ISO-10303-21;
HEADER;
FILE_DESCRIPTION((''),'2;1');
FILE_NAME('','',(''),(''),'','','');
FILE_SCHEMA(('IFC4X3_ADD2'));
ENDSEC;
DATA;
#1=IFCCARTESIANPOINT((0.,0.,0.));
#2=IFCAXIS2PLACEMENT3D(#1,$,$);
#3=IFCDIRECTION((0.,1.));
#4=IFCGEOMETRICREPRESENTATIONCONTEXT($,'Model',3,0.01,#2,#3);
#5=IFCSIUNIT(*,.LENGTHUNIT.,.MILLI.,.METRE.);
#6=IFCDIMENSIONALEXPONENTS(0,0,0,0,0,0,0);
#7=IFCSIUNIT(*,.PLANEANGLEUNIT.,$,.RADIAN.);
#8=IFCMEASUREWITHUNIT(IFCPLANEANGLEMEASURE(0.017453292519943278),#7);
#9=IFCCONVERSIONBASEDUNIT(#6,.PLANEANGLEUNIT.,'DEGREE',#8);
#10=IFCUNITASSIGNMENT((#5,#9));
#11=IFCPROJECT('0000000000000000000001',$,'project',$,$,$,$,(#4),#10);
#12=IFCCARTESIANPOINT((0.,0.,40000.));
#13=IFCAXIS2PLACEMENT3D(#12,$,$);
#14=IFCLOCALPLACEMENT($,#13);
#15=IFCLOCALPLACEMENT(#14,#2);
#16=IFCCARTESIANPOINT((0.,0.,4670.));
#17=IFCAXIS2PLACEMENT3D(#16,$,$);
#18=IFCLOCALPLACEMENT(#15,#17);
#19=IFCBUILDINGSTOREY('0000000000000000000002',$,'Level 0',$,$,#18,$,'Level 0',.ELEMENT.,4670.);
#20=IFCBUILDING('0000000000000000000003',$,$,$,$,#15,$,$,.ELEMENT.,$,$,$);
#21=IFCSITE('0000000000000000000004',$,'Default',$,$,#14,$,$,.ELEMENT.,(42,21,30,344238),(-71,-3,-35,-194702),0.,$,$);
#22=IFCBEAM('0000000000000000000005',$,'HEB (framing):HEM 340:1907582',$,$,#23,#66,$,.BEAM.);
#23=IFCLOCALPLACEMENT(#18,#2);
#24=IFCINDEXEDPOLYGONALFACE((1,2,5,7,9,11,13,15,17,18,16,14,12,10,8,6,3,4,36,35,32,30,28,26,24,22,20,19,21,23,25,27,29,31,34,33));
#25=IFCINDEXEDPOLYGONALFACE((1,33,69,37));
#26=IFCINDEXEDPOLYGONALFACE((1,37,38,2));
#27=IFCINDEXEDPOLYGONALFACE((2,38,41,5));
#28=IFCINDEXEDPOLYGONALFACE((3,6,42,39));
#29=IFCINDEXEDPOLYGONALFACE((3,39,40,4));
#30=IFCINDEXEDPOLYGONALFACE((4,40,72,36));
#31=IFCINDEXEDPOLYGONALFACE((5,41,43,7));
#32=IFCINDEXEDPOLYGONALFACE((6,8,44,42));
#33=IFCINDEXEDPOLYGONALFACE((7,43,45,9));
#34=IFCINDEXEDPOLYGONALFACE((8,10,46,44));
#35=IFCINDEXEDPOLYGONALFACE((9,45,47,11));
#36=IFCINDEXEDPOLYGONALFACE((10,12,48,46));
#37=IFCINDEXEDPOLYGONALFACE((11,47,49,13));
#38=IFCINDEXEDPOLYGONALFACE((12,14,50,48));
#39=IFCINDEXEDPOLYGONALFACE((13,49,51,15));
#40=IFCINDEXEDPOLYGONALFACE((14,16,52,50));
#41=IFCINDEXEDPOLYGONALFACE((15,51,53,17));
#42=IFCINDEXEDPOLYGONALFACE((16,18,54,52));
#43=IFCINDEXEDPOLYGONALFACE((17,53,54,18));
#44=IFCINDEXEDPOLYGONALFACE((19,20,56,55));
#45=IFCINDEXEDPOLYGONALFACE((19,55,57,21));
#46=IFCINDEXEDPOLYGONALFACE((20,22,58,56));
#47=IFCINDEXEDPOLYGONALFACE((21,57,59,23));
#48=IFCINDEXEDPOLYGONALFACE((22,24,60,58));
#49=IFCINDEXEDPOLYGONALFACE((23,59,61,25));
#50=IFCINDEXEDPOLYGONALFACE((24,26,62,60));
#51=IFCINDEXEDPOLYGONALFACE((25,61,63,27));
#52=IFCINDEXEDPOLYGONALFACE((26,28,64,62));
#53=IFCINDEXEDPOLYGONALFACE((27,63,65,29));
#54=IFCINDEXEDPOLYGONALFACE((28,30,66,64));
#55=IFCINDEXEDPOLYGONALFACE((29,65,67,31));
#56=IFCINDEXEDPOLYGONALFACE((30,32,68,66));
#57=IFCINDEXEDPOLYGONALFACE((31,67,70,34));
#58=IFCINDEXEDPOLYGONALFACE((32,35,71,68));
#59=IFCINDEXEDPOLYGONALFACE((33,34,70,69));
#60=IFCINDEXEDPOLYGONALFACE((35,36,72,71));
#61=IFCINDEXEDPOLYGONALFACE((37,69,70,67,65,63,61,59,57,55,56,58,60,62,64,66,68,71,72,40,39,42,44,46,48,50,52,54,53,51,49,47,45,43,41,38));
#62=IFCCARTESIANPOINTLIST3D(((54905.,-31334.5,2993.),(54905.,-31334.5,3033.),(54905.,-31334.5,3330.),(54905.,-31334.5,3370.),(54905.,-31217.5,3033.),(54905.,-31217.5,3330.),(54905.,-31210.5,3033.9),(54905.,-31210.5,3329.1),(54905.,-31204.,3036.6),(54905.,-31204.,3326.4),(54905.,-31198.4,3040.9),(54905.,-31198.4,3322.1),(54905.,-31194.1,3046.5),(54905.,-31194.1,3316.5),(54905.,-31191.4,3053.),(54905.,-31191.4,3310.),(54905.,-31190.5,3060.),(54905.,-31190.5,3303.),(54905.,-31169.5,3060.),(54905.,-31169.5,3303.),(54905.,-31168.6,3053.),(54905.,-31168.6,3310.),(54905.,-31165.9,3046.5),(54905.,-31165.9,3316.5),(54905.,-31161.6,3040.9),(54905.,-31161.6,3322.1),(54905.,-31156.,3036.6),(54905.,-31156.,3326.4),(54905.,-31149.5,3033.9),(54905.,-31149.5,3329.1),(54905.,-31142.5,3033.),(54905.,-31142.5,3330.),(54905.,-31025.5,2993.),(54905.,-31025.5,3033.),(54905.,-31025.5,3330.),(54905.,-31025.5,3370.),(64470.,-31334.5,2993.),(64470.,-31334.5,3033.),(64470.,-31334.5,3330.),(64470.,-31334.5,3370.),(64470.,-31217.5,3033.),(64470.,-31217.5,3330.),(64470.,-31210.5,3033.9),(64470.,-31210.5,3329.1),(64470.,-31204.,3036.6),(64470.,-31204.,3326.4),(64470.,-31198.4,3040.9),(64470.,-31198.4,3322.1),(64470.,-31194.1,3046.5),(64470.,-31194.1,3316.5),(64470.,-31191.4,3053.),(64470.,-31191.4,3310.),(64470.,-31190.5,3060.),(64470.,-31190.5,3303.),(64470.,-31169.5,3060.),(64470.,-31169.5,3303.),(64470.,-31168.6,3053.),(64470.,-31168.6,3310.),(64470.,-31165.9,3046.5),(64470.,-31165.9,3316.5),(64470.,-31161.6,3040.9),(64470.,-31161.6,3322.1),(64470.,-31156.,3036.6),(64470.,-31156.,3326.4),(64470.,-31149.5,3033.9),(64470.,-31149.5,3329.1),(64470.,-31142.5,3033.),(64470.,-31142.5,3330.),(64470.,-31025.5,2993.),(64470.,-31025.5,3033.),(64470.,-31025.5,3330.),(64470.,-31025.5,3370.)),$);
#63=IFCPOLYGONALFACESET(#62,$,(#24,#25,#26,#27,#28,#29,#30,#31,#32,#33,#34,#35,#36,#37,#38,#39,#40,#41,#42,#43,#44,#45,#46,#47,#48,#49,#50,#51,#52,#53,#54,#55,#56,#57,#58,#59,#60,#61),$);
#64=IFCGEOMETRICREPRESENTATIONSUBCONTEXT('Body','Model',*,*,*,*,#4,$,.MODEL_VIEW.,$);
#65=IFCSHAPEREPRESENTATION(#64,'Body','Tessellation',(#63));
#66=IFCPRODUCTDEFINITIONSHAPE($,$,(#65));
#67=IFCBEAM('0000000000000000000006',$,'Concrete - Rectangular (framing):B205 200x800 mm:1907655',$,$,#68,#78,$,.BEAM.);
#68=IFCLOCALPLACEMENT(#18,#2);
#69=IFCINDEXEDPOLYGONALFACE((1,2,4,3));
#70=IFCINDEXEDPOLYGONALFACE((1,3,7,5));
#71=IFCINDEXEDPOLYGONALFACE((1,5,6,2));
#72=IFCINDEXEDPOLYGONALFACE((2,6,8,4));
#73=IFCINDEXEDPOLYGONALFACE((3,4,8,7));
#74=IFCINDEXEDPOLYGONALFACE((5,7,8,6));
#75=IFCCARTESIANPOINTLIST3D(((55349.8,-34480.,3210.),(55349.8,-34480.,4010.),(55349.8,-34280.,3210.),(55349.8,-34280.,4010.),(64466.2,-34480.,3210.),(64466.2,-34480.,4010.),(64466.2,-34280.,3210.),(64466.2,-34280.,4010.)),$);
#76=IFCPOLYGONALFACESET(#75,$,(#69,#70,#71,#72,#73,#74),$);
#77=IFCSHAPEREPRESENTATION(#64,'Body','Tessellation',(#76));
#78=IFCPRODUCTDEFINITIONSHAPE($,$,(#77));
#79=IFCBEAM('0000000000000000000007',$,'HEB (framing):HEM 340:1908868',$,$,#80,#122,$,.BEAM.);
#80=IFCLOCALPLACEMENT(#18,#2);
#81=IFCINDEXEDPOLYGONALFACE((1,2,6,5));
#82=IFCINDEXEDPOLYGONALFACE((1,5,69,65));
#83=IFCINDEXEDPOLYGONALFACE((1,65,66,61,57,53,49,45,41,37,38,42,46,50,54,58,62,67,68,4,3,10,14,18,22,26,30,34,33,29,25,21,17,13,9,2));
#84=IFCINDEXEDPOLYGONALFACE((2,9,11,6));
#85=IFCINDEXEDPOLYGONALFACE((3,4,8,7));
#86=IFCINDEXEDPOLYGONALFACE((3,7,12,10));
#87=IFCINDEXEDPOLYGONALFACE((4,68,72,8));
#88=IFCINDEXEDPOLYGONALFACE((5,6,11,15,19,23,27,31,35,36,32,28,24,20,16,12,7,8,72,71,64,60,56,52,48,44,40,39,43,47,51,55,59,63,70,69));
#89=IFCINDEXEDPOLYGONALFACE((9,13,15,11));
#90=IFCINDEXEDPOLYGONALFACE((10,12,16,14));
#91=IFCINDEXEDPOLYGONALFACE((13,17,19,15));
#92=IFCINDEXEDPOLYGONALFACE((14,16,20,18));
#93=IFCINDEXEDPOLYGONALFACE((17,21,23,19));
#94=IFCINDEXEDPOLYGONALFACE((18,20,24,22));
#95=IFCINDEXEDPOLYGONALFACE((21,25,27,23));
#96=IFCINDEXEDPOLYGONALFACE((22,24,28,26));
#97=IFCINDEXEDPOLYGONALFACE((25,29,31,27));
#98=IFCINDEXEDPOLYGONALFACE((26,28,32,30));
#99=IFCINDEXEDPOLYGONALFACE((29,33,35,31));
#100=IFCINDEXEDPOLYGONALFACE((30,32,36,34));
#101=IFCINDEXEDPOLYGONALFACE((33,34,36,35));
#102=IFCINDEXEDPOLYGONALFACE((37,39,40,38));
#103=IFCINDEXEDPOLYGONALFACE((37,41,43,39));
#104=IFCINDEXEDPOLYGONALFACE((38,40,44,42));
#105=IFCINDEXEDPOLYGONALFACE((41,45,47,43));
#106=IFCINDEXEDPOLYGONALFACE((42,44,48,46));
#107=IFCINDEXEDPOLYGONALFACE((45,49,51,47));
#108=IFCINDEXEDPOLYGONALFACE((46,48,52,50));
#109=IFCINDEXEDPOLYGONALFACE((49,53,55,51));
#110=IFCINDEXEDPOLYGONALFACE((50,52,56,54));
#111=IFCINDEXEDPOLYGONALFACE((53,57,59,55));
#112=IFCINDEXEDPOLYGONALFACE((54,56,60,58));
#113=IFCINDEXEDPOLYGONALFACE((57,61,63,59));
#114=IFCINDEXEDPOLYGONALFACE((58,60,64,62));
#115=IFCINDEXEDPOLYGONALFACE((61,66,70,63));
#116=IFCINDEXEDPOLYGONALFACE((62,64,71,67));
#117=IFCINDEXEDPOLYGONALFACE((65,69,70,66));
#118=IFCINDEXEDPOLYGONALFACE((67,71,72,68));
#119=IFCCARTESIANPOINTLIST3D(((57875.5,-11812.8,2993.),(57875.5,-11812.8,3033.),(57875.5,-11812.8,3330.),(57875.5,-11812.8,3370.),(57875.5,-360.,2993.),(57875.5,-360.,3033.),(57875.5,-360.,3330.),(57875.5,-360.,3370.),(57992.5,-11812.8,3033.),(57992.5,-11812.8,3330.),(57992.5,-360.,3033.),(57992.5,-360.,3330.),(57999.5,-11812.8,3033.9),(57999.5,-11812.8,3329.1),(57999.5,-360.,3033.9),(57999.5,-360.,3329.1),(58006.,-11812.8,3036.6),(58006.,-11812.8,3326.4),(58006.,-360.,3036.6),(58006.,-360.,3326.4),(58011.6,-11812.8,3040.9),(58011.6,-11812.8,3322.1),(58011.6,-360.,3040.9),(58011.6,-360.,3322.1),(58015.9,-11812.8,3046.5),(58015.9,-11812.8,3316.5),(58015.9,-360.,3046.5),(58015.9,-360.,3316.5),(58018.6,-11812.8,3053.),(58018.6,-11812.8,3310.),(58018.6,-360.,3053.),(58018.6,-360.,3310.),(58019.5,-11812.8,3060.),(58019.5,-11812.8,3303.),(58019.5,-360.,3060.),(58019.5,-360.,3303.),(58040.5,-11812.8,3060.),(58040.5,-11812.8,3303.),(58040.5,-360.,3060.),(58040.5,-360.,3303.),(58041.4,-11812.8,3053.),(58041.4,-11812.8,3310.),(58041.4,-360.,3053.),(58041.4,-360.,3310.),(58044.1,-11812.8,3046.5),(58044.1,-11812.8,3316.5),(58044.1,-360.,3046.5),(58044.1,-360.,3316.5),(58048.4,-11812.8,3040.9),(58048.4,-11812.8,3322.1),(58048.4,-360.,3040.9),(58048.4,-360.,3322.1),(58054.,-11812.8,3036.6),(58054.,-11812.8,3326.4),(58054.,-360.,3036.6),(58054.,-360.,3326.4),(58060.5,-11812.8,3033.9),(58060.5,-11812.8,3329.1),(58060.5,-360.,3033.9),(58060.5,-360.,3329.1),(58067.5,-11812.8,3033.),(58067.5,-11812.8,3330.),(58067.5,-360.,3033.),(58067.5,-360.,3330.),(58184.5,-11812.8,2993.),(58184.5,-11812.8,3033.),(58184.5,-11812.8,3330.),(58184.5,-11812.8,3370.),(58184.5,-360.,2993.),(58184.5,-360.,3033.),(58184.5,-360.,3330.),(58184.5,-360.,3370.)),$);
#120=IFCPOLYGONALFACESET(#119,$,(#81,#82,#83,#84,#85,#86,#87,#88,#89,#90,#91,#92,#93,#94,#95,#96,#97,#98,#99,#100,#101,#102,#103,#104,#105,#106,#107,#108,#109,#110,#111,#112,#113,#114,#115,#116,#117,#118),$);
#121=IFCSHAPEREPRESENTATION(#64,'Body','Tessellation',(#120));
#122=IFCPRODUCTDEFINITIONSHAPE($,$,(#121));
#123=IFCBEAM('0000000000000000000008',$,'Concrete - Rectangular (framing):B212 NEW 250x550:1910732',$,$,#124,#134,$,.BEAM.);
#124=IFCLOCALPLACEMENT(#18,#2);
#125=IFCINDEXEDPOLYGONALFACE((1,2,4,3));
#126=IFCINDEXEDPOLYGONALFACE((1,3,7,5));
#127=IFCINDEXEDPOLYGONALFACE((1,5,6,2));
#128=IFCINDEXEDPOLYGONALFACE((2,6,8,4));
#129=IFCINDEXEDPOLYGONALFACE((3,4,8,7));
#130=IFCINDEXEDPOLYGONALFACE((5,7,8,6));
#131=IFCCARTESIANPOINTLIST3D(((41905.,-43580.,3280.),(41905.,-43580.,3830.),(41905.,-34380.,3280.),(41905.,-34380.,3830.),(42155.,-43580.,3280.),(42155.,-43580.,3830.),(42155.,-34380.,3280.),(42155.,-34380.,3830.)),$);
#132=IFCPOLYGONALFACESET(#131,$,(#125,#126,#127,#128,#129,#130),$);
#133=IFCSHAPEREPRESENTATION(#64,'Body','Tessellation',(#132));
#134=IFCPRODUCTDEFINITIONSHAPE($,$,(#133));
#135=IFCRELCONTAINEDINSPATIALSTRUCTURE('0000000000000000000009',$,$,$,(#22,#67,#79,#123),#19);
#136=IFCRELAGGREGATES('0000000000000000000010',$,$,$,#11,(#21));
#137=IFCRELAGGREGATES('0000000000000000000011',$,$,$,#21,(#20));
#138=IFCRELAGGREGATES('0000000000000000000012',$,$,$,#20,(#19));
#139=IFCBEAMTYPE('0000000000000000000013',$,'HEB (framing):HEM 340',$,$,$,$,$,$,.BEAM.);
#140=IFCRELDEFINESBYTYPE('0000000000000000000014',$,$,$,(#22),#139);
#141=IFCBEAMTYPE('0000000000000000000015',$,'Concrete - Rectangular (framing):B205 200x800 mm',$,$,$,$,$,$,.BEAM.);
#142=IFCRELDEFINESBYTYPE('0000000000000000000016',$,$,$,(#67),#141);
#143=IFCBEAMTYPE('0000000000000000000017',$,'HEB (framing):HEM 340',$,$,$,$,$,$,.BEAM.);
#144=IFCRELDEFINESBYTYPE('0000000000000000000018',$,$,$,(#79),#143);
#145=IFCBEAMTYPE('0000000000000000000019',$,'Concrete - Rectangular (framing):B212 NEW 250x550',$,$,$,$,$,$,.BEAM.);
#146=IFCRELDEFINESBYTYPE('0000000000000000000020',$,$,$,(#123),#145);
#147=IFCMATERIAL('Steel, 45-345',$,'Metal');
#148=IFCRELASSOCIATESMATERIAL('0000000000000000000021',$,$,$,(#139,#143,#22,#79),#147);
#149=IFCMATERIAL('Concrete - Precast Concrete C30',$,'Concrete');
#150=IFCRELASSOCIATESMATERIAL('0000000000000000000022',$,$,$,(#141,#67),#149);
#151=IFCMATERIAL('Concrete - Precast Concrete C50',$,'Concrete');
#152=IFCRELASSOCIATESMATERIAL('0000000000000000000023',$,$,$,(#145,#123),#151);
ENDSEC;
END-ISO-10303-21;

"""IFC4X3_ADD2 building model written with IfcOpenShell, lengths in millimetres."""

from ifc_helpers import new_model, entity, si_unit, converted_unit, direction, frame, frame_2d, origin, origin_2d_with_axis, place, context, subcontext, project, spatial, polyline, circle_curve, parameter, trimmed, segment, composite_curve, rectangle, outline, extrude, source, transform, mapped, material, material_profile, profile_set, profile_usage, type_object, type_shapes, element, save


model = new_model("IFC4X3_ADD2")

# Units and contexts
model_context = context("Model", 3, precision=0.01, world=origin(), true_north=direction((0.0, 1.0)))
body_context = subcontext(model_context, "Body", "Model", "MODEL_VIEW")
ifc_project = project(units=[si_unit("LENGTHUNIT", "METRE", prefix="MILLI"), converted_unit("PLANEANGLEUNIT", "DEGREE", entity("IfcPlaneAngleMeasure", 0.017453292519943278), si_unit("PLANEANGLEUNIT", "RADIAN"), dimensions=[0, 0, 0, 0, 0, 0, 0])], contexts=[model_context])

# Site, building, storey
site_placement = place(None, frame((0.0, 0.0, 40000.0)))
site = spatial("IfcSite", under=ifc_project, at=site_placement, Name="Default", CompositionType="ELEMENT", RefLatitude=(42, 21, 30, 344238), RefLongitude=(-71, -3, -35, -194702), RefElevation=0.0)
building_placement = place(site_placement, origin())
building = spatial("IfcBuilding", under=site, at=building_placement, CompositionType="ELEMENT")
storey_placement = place(building_placement, frame((0.0, 0.0, 4670.0)))
storey = spatial("IfcBuildingStorey", under=building, at=storey_placement, Name="Level 0", LongName="Level 0", CompositionType="ELEMENT", Elevation=4670.0)

# Shared definitions
ifc_material_1 = material(Name="Steel, 45-345", Category="Metal")

# Beams
ifc_material_profile_1 = material_profile(ifc_material_1, outline(composite_curve([segment(polyline([(-154.5, -148.5), (-154.5, -188.5)]), True, "CONTINUOUS"), segment(polyline([(-154.5, -188.5), (154.5, -188.5)]), True, "CONTINUOUS"), segment(polyline([(154.5, -188.5), (154.5, -148.5)]), True, "CONTINUOUS"), segment(polyline([(154.5, -148.5), (37.5, -148.5)]), True, "CONTINUOUS"), segment(trimmed(circle_curve(frame_2d((37.5, -121.5), x_axis=(1.0, 0.0)), 27.0), [parameter(180.0)], [parameter(270.0)], True, "PARAMETER"), False, "CONTINUOUS"), segment(polyline([(10.5, -121.5), (10.5, 121.5)]), True, "CONTINUOUS"), segment(trimmed(circle_curve(frame_2d((37.5, 121.5), x_axis=(1.0, 0.0)), 27.0), [parameter(90.0)], [parameter(180.0)], True, "PARAMETER"), False, "CONTINUOUS"), segment(polyline([(37.5, 148.5), (154.5, 148.5)]), True, "CONTINUOUS"), segment(polyline([(154.5, 148.5), (154.5, 188.5)]), True, "CONTINUOUS"), segment(polyline([(154.5, 188.5), (-154.5, 188.5)]), True, "CONTINUOUS"), segment(polyline([(-154.5, 188.5), (-154.5, 148.5)]), True, "CONTINUOUS"), segment(polyline([(-154.5, 148.5), (-37.5, 148.5)]), True, "CONTINUOUS"), segment(trimmed(circle_curve(frame_2d((-37.5, 121.5), x_axis=(1.0, 0.0)), 27.0), [parameter(360.0)], [parameter(90.0)], True, "PARAMETER"), False, "CONTINUOUS"), segment(polyline([(-10.5, 121.5), (-10.5, -121.5)]), True, "CONTINUOUS"), segment(trimmed(circle_curve(frame_2d((-37.5, -121.5), x_axis=(1.0, 0.0)), 27.0), [parameter(270.0)], [parameter(0.0)], True, "PARAMETER"), False, "CONTINUOUS"), segment(polyline([(-37.5, -148.5), (-154.5, -148.5)]), True, "CONTINUOUS")], self_intersect=False)), Name="HEM 340")
ifc_profile_set_1 = profile_set([ifc_material_profile_1], Name="HEM 340")
ifc_profile_usage_1 = profile_usage(ifc_profile_set_1, cardinal=8)
beam_type_1 = type_object("IfcBeamType", Name="HEB (framing):HEM 340", PredefinedType="BEAM", material=ifc_profile_set_1)
shared_shape_1 = source(origin(), body_context, "Body", "SweptSolid", [
    extrude(outline(composite_curve([segment(polyline([(-154.5, -148.5), (-154.5, -188.5)]), True, "CONTINUOUS"), segment(polyline([(-154.5, -188.5), (154.5, -188.5)]), True, "CONTINUOUS"), segment(polyline([(154.5, -188.5), (154.5, -148.5)]), True, "CONTINUOUS"), segment(polyline([(154.5, -148.5), (37.5, -148.5)]), True, "CONTINUOUS"), segment(trimmed(circle_curve(frame_2d((37.5, -121.5), x_axis=(1.0, 0.0)), 27.0), [parameter(180.0)], [parameter(270.0)], True, "PARAMETER"), False, "CONTINUOUS"), segment(polyline([(10.5, -121.5), (10.5, 121.5)]), True, "CONTINUOUS"), segment(trimmed(circle_curve(frame_2d((37.5, 121.5), x_axis=(1.0, 0.0)), 27.0), [parameter(90.0)], [parameter(180.0)], True, "PARAMETER"), False, "CONTINUOUS"), segment(polyline([(37.5, 148.5), (154.5, 148.5)]), True, "CONTINUOUS"), segment(polyline([(154.5, 148.5), (154.5, 188.5)]), True, "CONTINUOUS"), segment(polyline([(154.5, 188.5), (-154.5, 188.5)]), True, "CONTINUOUS"), segment(polyline([(-154.5, 188.5), (-154.5, 148.5)]), True, "CONTINUOUS"), segment(polyline([(-154.5, 148.5), (-37.5, 148.5)]), True, "CONTINUOUS"), segment(trimmed(circle_curve(frame_2d((-37.5, 121.5), x_axis=(1.0, 0.0)), 27.0), [parameter(360.0)], [parameter(90.0)], True, "PARAMETER"), False, "CONTINUOUS"), segment(polyline([(-10.5, 121.5), (-10.5, -121.5)]), True, "CONTINUOUS"), segment(trimmed(circle_curve(frame_2d((-37.5, -121.5), x_axis=(1.0, 0.0)), 27.0), [parameter(270.0)], [parameter(0.0)], True, "PARAMETER"), False, "CONTINUOUS"), segment(polyline([(-37.5, -148.5), (-154.5, -148.5)]), True, "CONTINUOUS")], self_intersect=False)), frame((-4680.0, 0.0, 0.0), z_axis=(-1.0, 0.0, 0.0), x_axis=(0.0, -1.0, 0.0)), (0.0, 0.0, -1.0), 9565.0),
])
type_shapes(beam_type_1, [shared_shape_1])
beam_1_placement = place(storey_placement, frame((59585.0, -31180.0, 3181.5)))
element("IfcBeam", 1, at=beam_1_placement, inside=storey, type_object=beam_type_1, material=ifc_profile_usage_1, Name="HEB (framing):HEM 340:1907582", PredefinedType="BEAM", context=body_context, shape_type="MappedRepresentation", body=[
    mapped(shared_shape_1, transform((0.0, 0.0, 0.0), scale=1.0)),
])
ifc_material_2 = material(Name="Concrete - Precast Concrete C30", Category="Concrete")
ifc_material_profile_2 = material_profile(ifc_material_2, rectangle(XDim=9116.4, YDim=200.0, at=origin_2d_with_axis()), Name="B205 200x800 mm")
ifc_profile_set_2 = profile_set([ifc_material_profile_2], Name="B205 200x800 mm")
ifc_profile_usage_2 = profile_usage(ifc_profile_set_2, cardinal=8)
beam_type_2 = type_object("IfcBeamType", Name="Concrete - Rectangular (framing):B205 200x800 mm", PredefinedType="BEAM", material=ifc_profile_set_2)
shared_shape_2 = source(origin(), body_context, "Body", "SweptSolid", [
    extrude(rectangle(XDim=9116.4, YDim=200.0, at=origin_2d_with_axis()), frame((453.0, 0.0, -400.0), z_axis=(0.0, 0.0, 1.0), x_axis=(-1.0, 0.0, 0.0)), (0.0, 0.0, 1.0), 800.0),
])
type_shapes(beam_type_2, [shared_shape_2])
beam_2_placement = place(storey_placement, frame((59455.0, -34380.0, 3610.0)))
element("IfcBeam", 2, at=beam_2_placement, inside=storey, type_object=beam_type_2, material=ifc_profile_usage_2, Name="Concrete - Rectangular (framing):B205 200x800 mm:1907655", PredefinedType="BEAM", context=body_context, shape_type="MappedRepresentation", body=[
    mapped(shared_shape_2, transform((0.0, 0.0, 0.0), scale=1.0)),
])
beam_type_3 = type_object("IfcBeamType", Name="HEB (framing):HEM 340", PredefinedType="BEAM", material=ifc_profile_set_1)
shared_shape_3 = source(origin(), body_context, "Body", "SweptSolid", [
    extrude(outline(composite_curve([segment(polyline([(-154.5, -148.5), (-154.5, -188.5)]), True, "CONTINUOUS"), segment(polyline([(-154.5, -188.5), (154.5, -188.5)]), True, "CONTINUOUS"), segment(polyline([(154.5, -188.5), (154.5, -148.5)]), True, "CONTINUOUS"), segment(polyline([(154.5, -148.5), (37.5, -148.5)]), True, "CONTINUOUS"), segment(trimmed(circle_curve(frame_2d((37.5, -121.5), x_axis=(1.0, 0.0)), 27.0), [parameter(180.0)], [parameter(270.0)], True, "PARAMETER"), False, "CONTINUOUS"), segment(polyline([(10.5, -121.5), (10.5, 121.5)]), True, "CONTINUOUS"), segment(trimmed(circle_curve(frame_2d((37.5, 121.5), x_axis=(1.0, 0.0)), 27.0), [parameter(90.0)], [parameter(180.0)], True, "PARAMETER"), False, "CONTINUOUS"), segment(polyline([(37.5, 148.5), (154.5, 148.5)]), True, "CONTINUOUS"), segment(polyline([(154.5, 148.5), (154.5, 188.5)]), True, "CONTINUOUS"), segment(polyline([(154.5, 188.5), (-154.5, 188.5)]), True, "CONTINUOUS"), segment(polyline([(-154.5, 188.5), (-154.5, 148.5)]), True, "CONTINUOUS"), segment(polyline([(-154.5, 148.5), (-37.5, 148.5)]), True, "CONTINUOUS"), segment(trimmed(circle_curve(frame_2d((-37.5, 121.5), x_axis=(1.0, 0.0)), 27.0), [parameter(360.0)], [parameter(90.0)], True, "PARAMETER"), False, "CONTINUOUS"), segment(polyline([(-10.5, 121.5), (-10.5, -121.5)]), True, "CONTINUOUS"), segment(trimmed(circle_curve(frame_2d((-37.5, -121.5), x_axis=(1.0, 0.0)), 27.0), [parameter(270.0)], [parameter(0.0)], True, "PARAMETER"), False, "CONTINUOUS"), segment(polyline([(-37.5, -148.5), (-154.5, -148.5)]), True, "CONTINUOUS")], self_intersect=False)), frame((-5860.0, 0.0, 0.0), z_axis=(-1.0, 0.0, 0.0), x_axis=(0.0, -1.0, 0.0)), (0.0, 0.0, -1.0), 11452.8),
])
type_shapes(beam_type_3, [shared_shape_3])
beam_3_placement = place(storey_placement, frame((58030.0, -6220.0, 3181.5), z_axis=(0.0, 0.0, 1.0), x_axis=(0.0, -1.0, 0.0)))
element("IfcBeam", 3, at=beam_3_placement, inside=storey, type_object=beam_type_3, material=ifc_profile_usage_1, Name="HEB (framing):HEM 340:1908868", PredefinedType="BEAM", context=body_context, shape_type="MappedRepresentation", body=[
    mapped(shared_shape_3, transform((0.0, 0.0, 0.0), scale=1.0)),
])
ifc_material_3 = material(Name="Concrete - Precast Concrete C50", Category="Concrete")
ifc_material_profile_3 = material_profile(ifc_material_3, rectangle(XDim=9200.0, YDim=250.0, at=origin_2d_with_axis()), Name="B212 NEW 250x550")
ifc_profile_set_3 = profile_set([ifc_material_profile_3], Name="B212 NEW 250x550")
ifc_profile_usage_3 = profile_usage(ifc_profile_set_3, cardinal=8)
beam_type_4 = type_object("IfcBeamType", Name="Concrete - Rectangular (framing):B212 NEW 250x550", PredefinedType="BEAM", material=ifc_profile_set_3)
shared_shape_4 = source(origin(), body_context, "Body", "SweptSolid", [
    extrude(rectangle(XDim=9200.0, YDim=250.0, at=origin_2d_with_axis()), frame((0.0, 0.0, -275.0), z_axis=(0.0, 0.0, 1.0), x_axis=(-1.0, 0.0, 0.0)), (0.0, 0.0, 1.0), 550.0),
])
type_shapes(beam_type_4, [shared_shape_4])
for number, where, z_axis, x_axis, name in (
    (4, (42030.0, -38980.0, 3555.0), (0.0, 0.0, 1.0), (0.0, 1.0, 0.0), "Concrete - Rectangular (framing):B212 NEW 250x550:1910732"),
):
    element("IfcBeam", number, at=place(storey_placement, frame(where, z_axis=z_axis, x_axis=x_axis)), inside=storey, type_object=beam_type_4, material=ifc_profile_usage_3, Name=name, PredefinedType="BEAM", context=body_context, shape_type="MappedRepresentation", body=[
        mapped(shared_shape_4, transform((0.0, 0.0, 0.0), scale=1.0)),
    ])

save(model, "model.ifc")
